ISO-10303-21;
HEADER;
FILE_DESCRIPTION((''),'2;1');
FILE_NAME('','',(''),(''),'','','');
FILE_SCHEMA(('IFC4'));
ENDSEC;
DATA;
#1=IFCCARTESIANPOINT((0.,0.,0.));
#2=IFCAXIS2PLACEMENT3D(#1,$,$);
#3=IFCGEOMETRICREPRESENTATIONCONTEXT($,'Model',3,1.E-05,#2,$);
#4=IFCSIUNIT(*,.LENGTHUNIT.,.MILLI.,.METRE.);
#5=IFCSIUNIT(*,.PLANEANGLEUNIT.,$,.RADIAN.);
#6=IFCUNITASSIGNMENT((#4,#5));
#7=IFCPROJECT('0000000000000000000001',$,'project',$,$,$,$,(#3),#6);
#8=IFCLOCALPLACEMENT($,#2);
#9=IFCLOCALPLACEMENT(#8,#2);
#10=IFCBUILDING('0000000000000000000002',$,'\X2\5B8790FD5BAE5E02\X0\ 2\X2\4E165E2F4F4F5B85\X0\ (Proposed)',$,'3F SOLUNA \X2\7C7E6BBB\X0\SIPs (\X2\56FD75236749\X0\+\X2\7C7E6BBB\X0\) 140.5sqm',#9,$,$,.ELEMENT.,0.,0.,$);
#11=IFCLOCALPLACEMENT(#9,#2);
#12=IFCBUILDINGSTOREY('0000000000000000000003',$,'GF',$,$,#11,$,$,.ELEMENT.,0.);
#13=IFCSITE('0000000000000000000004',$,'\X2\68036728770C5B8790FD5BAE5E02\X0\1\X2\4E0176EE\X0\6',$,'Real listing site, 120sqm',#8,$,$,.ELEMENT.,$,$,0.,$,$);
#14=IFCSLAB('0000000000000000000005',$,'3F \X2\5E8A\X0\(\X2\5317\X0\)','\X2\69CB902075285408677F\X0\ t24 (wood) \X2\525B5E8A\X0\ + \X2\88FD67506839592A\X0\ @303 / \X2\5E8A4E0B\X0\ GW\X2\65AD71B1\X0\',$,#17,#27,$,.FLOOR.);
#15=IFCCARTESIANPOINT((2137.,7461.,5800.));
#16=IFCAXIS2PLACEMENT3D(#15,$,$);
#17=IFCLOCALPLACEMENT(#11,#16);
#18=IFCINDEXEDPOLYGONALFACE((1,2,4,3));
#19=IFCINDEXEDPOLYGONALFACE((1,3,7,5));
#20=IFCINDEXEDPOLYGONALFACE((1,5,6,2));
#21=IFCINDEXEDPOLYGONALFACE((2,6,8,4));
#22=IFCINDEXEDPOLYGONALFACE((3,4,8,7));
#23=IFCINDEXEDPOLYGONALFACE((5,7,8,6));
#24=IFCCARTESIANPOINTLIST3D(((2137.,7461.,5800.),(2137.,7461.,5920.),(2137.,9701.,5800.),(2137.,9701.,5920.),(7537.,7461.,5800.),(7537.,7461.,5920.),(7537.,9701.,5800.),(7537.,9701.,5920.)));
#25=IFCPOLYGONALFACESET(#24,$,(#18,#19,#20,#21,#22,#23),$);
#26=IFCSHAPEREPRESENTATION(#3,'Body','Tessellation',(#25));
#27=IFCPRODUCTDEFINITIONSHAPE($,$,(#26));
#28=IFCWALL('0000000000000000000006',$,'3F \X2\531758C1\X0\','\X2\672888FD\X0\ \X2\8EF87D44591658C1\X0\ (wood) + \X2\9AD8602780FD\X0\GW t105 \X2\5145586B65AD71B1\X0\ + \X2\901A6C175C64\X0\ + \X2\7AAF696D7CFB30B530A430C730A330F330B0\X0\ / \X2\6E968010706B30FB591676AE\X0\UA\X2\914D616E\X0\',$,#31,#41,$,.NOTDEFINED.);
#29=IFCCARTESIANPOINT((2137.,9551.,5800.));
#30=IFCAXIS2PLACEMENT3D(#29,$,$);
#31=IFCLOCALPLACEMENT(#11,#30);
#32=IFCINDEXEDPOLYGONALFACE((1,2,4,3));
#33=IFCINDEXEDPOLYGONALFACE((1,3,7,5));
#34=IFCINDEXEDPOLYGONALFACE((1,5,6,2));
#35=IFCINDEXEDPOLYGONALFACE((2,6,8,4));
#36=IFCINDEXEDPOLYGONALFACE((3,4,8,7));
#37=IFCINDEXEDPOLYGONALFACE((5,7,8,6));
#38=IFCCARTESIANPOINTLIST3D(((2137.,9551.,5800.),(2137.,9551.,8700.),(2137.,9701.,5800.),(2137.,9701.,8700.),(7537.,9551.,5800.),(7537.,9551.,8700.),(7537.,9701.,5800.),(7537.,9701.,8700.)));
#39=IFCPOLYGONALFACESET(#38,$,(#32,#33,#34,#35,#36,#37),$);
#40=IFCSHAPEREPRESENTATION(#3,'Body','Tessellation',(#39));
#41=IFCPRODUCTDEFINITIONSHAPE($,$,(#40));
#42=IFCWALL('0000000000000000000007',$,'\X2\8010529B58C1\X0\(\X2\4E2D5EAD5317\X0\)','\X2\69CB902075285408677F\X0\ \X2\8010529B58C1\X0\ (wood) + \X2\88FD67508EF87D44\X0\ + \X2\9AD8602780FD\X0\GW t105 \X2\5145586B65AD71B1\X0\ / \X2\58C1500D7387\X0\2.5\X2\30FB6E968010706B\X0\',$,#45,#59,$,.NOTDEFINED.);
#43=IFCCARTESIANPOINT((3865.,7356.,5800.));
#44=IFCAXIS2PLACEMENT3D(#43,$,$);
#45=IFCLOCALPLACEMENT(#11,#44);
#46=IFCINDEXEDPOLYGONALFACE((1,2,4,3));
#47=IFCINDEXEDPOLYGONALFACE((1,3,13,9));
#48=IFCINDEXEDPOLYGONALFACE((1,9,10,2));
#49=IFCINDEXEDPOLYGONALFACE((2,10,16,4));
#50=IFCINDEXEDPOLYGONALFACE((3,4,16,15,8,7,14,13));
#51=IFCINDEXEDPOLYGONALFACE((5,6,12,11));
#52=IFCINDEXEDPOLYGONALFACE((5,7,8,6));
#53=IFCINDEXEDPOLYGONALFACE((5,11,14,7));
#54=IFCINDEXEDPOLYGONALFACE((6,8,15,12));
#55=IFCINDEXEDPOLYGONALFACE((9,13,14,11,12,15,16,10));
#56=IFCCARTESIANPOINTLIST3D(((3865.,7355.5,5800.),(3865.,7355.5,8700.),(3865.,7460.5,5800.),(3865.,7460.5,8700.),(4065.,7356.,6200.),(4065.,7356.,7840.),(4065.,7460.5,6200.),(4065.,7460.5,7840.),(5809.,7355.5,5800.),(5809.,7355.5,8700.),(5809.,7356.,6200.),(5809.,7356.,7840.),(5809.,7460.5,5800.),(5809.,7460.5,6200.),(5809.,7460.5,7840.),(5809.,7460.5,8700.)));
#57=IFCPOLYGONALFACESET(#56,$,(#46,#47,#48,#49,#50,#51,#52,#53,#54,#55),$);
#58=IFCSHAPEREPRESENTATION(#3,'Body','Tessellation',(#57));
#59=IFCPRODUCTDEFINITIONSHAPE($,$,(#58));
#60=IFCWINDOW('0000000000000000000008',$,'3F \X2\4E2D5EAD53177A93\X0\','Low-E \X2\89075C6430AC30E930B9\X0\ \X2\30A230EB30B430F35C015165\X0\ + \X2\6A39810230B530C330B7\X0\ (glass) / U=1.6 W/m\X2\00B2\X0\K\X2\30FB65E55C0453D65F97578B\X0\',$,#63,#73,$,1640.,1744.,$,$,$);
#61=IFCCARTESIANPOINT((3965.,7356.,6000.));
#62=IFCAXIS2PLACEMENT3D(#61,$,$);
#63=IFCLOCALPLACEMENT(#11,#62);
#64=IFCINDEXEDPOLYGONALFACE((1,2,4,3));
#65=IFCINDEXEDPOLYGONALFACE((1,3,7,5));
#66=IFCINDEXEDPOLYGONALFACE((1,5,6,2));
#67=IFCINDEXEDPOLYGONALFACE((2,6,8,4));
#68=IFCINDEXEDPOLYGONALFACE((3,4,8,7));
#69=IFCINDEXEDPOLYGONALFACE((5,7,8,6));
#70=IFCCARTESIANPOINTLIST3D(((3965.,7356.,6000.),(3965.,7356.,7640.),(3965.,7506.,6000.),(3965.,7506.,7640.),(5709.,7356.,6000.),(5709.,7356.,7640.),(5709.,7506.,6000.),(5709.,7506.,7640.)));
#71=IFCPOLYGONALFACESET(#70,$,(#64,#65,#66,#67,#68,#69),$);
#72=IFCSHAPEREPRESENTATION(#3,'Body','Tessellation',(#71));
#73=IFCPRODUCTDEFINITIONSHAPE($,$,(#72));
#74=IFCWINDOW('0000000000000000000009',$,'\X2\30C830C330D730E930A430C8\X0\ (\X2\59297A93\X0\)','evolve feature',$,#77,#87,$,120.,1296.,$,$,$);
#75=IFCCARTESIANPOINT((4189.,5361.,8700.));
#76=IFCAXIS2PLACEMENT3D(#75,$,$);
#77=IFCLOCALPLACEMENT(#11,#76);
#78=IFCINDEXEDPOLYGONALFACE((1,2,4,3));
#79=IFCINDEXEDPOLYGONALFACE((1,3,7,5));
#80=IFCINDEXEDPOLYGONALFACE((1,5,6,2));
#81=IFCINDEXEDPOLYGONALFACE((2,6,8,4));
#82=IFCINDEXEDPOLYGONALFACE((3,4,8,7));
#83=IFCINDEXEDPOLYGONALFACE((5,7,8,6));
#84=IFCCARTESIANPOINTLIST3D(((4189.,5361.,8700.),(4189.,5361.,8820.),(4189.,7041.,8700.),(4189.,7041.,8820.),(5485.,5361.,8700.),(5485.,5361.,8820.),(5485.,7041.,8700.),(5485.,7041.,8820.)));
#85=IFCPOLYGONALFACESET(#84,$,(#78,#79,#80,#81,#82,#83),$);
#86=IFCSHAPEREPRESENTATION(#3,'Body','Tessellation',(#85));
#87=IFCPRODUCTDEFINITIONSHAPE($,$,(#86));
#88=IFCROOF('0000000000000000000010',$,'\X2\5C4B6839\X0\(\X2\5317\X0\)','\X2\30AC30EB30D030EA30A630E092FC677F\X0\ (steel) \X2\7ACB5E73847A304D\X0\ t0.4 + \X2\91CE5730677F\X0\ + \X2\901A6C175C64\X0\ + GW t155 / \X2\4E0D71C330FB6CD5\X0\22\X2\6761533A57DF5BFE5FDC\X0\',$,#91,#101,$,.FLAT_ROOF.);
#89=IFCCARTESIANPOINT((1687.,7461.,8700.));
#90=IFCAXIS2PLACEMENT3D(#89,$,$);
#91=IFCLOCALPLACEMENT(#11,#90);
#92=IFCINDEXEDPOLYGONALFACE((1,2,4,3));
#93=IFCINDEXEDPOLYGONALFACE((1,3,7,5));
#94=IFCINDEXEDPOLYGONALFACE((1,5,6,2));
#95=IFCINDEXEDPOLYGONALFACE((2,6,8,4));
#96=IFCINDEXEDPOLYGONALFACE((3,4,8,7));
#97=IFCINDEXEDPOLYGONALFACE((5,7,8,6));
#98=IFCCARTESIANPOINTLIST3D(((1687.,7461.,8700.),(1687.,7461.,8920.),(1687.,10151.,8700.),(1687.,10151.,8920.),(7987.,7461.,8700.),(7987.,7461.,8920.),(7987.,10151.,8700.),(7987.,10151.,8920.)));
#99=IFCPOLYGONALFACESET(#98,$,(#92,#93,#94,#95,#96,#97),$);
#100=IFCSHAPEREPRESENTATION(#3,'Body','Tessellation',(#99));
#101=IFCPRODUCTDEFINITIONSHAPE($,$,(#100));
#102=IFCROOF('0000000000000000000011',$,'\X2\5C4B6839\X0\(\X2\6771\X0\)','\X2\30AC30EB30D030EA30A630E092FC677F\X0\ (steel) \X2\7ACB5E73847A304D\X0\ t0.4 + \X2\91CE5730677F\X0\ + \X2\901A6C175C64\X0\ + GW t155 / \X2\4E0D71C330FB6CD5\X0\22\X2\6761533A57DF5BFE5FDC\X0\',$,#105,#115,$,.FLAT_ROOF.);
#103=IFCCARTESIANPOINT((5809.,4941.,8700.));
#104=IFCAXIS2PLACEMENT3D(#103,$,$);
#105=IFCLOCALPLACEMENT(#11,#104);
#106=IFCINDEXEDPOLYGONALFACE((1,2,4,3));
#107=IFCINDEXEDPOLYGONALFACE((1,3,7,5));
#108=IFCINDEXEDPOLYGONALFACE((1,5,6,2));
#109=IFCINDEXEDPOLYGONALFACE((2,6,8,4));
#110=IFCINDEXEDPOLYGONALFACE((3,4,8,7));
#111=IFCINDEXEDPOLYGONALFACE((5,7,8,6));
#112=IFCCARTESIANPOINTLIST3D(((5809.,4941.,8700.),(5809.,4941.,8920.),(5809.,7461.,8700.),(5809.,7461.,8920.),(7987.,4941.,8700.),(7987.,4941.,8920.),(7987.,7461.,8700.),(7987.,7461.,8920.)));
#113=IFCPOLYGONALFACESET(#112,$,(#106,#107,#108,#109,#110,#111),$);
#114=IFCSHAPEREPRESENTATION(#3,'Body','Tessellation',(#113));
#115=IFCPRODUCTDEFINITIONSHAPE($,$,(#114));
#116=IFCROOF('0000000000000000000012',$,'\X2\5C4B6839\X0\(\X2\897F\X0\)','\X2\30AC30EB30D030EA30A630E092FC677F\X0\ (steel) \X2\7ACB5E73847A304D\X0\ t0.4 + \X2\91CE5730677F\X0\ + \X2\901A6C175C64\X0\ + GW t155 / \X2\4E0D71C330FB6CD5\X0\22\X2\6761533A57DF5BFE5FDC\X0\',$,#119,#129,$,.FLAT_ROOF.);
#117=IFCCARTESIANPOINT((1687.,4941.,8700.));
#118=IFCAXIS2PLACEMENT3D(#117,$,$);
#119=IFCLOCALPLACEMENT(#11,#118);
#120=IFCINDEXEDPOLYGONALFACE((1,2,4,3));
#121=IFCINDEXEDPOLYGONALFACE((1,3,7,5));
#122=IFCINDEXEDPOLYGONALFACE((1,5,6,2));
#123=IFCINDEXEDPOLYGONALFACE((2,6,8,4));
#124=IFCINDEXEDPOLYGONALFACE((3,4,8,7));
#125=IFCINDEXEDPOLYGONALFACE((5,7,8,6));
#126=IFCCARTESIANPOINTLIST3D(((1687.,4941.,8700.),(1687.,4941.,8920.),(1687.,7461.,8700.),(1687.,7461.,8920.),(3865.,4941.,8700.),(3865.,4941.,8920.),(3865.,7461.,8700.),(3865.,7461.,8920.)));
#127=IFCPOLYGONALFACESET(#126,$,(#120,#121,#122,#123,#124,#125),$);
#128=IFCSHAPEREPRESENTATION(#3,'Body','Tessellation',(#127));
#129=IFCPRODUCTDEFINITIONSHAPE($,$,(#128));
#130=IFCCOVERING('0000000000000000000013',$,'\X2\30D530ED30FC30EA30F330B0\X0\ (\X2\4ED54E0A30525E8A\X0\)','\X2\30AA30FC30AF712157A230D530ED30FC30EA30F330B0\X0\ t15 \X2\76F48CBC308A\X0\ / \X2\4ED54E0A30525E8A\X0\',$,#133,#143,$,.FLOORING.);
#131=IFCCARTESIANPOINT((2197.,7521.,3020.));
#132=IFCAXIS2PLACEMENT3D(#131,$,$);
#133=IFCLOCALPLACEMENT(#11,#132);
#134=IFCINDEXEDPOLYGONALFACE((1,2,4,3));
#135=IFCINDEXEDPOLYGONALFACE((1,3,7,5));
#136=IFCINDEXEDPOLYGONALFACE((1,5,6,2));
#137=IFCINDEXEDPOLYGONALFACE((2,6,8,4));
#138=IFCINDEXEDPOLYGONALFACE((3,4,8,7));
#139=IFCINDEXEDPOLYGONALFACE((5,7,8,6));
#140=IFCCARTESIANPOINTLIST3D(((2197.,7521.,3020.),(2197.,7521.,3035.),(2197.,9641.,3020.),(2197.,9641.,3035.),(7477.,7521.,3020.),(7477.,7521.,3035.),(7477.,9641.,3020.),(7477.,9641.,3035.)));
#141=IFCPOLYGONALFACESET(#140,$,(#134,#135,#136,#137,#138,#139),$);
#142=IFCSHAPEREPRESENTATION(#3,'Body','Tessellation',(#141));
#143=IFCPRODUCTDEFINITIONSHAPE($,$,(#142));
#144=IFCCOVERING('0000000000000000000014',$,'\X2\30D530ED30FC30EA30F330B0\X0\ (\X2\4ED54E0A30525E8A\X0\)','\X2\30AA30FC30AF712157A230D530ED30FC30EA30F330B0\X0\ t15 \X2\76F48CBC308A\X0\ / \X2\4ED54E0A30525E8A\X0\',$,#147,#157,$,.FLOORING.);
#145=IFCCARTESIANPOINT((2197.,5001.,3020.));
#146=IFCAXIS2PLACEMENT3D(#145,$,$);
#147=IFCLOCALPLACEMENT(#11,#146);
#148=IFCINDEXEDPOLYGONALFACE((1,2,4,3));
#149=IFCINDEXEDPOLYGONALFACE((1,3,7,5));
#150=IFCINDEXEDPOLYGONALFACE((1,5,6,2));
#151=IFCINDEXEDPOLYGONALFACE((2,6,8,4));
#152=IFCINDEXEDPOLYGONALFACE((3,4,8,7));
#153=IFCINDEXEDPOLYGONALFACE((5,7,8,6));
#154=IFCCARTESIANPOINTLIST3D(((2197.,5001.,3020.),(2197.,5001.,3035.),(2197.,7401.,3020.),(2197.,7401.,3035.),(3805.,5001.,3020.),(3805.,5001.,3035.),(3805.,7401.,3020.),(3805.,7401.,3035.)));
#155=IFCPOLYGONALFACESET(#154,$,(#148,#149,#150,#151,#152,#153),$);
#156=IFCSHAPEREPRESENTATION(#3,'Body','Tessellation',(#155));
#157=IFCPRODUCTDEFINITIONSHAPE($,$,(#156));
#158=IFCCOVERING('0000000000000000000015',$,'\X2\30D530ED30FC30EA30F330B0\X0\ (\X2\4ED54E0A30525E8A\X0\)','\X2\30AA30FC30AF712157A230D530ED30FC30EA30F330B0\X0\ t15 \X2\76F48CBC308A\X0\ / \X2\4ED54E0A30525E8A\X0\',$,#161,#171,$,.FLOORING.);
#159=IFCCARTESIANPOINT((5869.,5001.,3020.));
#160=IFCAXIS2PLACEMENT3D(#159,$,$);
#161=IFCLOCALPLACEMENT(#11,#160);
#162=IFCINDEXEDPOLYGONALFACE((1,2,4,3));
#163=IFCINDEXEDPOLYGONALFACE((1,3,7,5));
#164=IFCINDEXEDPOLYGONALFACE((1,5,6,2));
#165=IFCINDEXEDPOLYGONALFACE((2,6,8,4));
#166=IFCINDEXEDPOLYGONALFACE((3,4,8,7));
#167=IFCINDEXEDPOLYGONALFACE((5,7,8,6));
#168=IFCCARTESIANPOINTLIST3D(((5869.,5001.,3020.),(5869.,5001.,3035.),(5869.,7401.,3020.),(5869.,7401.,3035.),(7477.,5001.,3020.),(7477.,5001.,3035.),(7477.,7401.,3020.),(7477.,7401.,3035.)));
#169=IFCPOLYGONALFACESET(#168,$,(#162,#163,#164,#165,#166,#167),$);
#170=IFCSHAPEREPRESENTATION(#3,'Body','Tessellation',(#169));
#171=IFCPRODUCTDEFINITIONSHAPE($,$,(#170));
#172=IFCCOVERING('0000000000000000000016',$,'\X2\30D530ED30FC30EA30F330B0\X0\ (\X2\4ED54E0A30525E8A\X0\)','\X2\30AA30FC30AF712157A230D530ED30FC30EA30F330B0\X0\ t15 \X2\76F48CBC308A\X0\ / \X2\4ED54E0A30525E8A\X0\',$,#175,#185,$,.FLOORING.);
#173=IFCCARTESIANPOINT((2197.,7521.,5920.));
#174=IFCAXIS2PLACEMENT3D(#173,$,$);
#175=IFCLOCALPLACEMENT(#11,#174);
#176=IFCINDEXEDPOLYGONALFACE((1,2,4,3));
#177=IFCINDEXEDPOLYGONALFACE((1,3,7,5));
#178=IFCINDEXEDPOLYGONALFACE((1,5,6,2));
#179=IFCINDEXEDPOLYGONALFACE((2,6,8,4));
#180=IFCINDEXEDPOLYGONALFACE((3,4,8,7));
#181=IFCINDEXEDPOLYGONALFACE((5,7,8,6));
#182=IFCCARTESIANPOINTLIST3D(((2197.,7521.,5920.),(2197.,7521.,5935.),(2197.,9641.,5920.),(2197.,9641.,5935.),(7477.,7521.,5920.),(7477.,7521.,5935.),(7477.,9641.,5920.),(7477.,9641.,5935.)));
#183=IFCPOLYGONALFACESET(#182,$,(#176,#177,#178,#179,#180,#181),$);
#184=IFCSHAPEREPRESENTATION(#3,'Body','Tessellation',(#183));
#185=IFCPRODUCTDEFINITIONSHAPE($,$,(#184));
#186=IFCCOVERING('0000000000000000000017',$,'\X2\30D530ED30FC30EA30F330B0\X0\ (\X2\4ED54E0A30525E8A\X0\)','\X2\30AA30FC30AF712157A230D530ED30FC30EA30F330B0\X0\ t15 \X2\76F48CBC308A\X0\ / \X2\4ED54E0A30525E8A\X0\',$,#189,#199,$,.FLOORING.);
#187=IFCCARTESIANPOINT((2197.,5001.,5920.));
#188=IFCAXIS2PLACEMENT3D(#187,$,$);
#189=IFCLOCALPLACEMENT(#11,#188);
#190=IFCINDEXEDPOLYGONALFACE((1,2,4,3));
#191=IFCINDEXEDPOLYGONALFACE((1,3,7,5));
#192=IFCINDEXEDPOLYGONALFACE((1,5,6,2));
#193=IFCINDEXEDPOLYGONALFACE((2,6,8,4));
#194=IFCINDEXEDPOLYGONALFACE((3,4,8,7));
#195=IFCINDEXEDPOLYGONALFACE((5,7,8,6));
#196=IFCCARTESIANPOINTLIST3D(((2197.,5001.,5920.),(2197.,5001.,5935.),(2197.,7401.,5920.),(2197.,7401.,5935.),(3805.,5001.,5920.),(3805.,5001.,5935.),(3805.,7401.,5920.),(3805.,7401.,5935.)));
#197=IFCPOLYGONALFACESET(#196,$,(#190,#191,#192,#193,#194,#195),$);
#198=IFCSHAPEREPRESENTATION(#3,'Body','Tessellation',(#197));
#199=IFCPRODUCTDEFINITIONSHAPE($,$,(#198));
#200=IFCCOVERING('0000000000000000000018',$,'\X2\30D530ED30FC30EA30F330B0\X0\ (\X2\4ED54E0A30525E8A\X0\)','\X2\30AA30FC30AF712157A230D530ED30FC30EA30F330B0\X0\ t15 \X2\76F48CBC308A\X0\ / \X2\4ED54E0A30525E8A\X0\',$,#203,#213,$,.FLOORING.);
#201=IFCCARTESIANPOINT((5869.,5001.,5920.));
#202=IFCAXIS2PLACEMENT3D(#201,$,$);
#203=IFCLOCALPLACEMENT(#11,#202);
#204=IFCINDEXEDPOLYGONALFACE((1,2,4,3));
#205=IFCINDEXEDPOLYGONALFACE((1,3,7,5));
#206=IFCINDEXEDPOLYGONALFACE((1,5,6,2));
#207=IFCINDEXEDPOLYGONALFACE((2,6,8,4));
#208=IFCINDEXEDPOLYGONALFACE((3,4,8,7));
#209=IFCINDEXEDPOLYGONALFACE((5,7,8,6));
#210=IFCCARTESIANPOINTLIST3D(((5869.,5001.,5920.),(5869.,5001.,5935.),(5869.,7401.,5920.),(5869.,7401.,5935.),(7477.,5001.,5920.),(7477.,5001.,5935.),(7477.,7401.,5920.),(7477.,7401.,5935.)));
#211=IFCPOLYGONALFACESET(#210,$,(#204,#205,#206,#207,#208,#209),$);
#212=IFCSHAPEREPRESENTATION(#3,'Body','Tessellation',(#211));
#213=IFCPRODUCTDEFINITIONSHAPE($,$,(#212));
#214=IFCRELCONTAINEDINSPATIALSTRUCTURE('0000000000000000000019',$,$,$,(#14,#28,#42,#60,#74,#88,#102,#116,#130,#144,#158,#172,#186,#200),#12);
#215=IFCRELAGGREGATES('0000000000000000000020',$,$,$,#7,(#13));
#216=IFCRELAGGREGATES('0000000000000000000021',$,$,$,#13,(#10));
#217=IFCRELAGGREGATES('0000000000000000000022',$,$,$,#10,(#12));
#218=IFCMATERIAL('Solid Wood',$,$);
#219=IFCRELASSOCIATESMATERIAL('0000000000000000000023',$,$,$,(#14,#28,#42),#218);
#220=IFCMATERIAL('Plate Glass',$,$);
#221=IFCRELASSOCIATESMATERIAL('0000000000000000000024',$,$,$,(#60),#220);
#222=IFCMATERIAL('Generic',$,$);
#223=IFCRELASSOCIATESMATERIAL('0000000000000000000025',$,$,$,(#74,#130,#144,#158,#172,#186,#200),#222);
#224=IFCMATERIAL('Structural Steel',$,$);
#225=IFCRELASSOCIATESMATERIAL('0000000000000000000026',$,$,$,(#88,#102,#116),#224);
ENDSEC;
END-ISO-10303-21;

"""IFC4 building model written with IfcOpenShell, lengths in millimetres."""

from ifc_helpers import new_model, si_unit, frame, frame_2d, origin, place, context, project, spatial, rectangle, extrude, material, element, fill, save


model = new_model("IFC4")

# Units and contexts
model_context = context("Model", 3, precision=1e-05, world=origin())
ifc_project = project(units=[si_unit("LENGTHUNIT", "METRE", prefix="MILLI"), si_unit("PLANEANGLEUNIT", "RADIAN")], contexts=[model_context])

# Site, building, storey
site_placement = place(None, origin())
site = spatial("IfcSite", under=ifc_project, at=site_placement, Name="栃木県宇都宮市1丁目6", ObjectType="Real listing site, 120sqm", CompositionType="ELEMENT", RefElevation=0.0)
building_placement = place(site_placement, origin())
building = spatial("IfcBuilding", under=site, at=building_placement, Name="宇都宮市 2世帯住宅 (Proposed)", ObjectType="3F SOLUNA 籾殻SIPs (国産杉+籾殻) 140.5sqm", CompositionType="ELEMENT", ElevationOfRefHeight=0.0, ElevationOfTerrain=0.0)
storey_placement = place(building_placement, origin())
storey = spatial("IfcBuildingStorey", under=building, at=storey_placement, Name="GF", CompositionType="ELEMENT", Elevation=0.0)

# Slab
ifc_material_1 = material(Name="Solid Wood")
slab_placement = place(storey_placement, frame((2137.0, 7461.0, 5800.0)))
element("IfcSlab", 1, at=slab_placement, inside=storey, material=ifc_material_1, Name="3F 床(北)", Description="構造用合板 t24 (wood) 剛床 + 製材根太 @303 / 床下 GW断熱", PredefinedType="FLOOR", context=model_context, shape_type="SweptSolid", body=[
    extrude(rectangle(XDim=5400.0, YDim=2240.0, at=frame_2d((2700.0, 1120.0))), frame((2137.0, 7461.0, 5800.0)), (0.0, 0.0, 1.0), 120.0),
])

# Wall
wall_1_placement = place(storey_placement, frame((2137.0, 9551.0, 5800.0)))
element("IfcWall", 2, at=wall_1_placement, inside=storey, material=ifc_material_1, Name="3F 北壁", Description="木製 軸組外壁 (wood) + 高性能GW t105 充填断熱 + 通気層 + 窯業系サイディング / 準耐火・外皮UA配慮", PredefinedType="NOTDEFINED", context=model_context, shape_type="SweptSolid", body=[
    extrude(rectangle(XDim=5400.0, YDim=150.0, at=frame_2d((2700.0, 75.0))), frame((2137.0, 9551.0, 5800.0)), (0.0, 0.0, 1.0), 2900.0),
])

# Wall, opening, window
wall_2_placement = place(storey_placement, frame((3865.0, 7356.0, 5800.0)))
wall_2 = element("IfcWall", 3, at=wall_2_placement, inside=storey, material=ifc_material_1, Name="耐力壁(中庭北)", Description="構造用合板 耐力壁 (wood) + 製材軸組 + 高性能GW t105 充填断熱 / 壁倍率2.5・準耐火", PredefinedType="NOTDEFINED", context=model_context, shape_type="SweptSolid", body=[
    extrude(rectangle(XDim=1944.0, YDim=105.0, at=frame_2d((972.0, 52.0))), frame((3865.0, 7356.0, 5800.0)), (0.0, 0.0, 1.0), 2900.0),
])
opening_placement = place(storey_placement, frame((3965.0, 7356.0, 6000.0)))
opening = element("IfcOpeningElement", 4, at=opening_placement, cuts=wall_2, PredefinedType="NOTDEFINED", context=model_context, shape_type="SweptSolid", body=[
    extrude(rectangle(XDim=1744.0, YDim=150.0, at=frame_2d((872.0, 75.0))), frame((3965.0, 7356.0, 6000.0)), (0.0, 0.0, 1.0), 1640.0),
])
ifc_material_2 = material(Name="Plate Glass")
window_1_placement = place(storey_placement, frame((3965.0, 7356.0, 6000.0)))
window_1 = element("IfcWindow", 5, at=window_1_placement, inside=storey, material=ifc_material_2, Name="3F 中庭北窓", Description="Low-E 複層ガラス アルゴン封入 + 樹脂サッシ (glass) / U=1.6 W/m²K・日射取得型", OverallHeight=1640.0, OverallWidth=1744.0, context=model_context, shape_type="SweptSolid", body=[
    extrude(rectangle(XDim=1744.0, YDim=150.0, at=frame_2d((872.0, 75.0))), frame((3965.0, 7356.0, 6000.0)), (0.0, 0.0, 1.0), 1640.0),
])
fill(opening, window_1)

# Window
ifc_material_3 = material(Name="Generic")
window_2_placement = place(storey_placement, frame((4189.0, 5361.0, 8700.0)))
element("IfcWindow", 6, at=window_2_placement, inside=storey, material=ifc_material_3, Name="トップライト (天窓)", Description="evolve feature", OverallHeight=120.0, OverallWidth=1296.0, context=model_context, shape_type="SweptSolid", body=[
    extrude(rectangle(XDim=1296.0, YDim=1680.0, at=frame_2d((648.0, 840.0))), frame((4189.0, 5361.0, 8700.0)), (0.0, 0.0, 1.0), 120.0),
])

# Roofs
ifc_material_4 = material(Name="Structural Steel")
roof_1_placement = place(storey_placement, frame((1687.0, 7461.0, 8700.0)))
element("IfcRoof", 7, at=roof_1_placement, inside=storey, material=ifc_material_4, Name="屋根(北)", Description="ガルバリウム鋼板 (steel) 立平葺き t0.4 + 野地板 + 通気層 + GW t155 / 不燃・法22条区域対応", PredefinedType="FLAT_ROOF", context=model_context, shape_type="SweptSolid", body=[
    extrude(rectangle(XDim=6300.0, YDim=2690.0, at=frame_2d((3150.0, 1345.0))), frame((1687.0, 7461.0, 8700.0)), (0.0, 0.0, 1.0), 220.0),
])
roof_2_placement = place(storey_placement, frame((5809.0, 4941.0, 8700.0)))
element("IfcRoof", 8, at=roof_2_placement, inside=storey, material=ifc_material_4, Name="屋根(東)", Description="ガルバリウム鋼板 (steel) 立平葺き t0.4 + 野地板 + 通気層 + GW t155 / 不燃・法22条区域対応", PredefinedType="FLAT_ROOF", context=model_context, shape_type="SweptSolid", body=[
    extrude(rectangle(XDim=2178.0, YDim=2520.0, at=frame_2d((1089.0, 1260.0))), frame((5809.0, 4941.0, 8700.0)), (0.0, 0.0, 1.0), 220.0),
])
roof_3_placement = place(storey_placement, frame((1687.0, 4941.0, 8700.0)))
element("IfcRoof", 9, at=roof_3_placement, inside=storey, material=ifc_material_4, Name="屋根(西)", Description="ガルバリウム鋼板 (steel) 立平葺き t0.4 + 野地板 + 通気層 + GW t155 / 不燃・法22条区域対応", PredefinedType="FLAT_ROOF", context=model_context, shape_type="SweptSolid", body=[
    extrude(rectangle(XDim=2178.0, YDim=2520.0, at=frame_2d((1089.0, 1260.0))), frame((1687.0, 4941.0, 8700.0)), (0.0, 0.0, 1.0), 220.0),
])

# Coverings
covering_1_placement = place(storey_placement, frame((2197.0, 7521.0, 3020.0)))
element("IfcCovering", 10, at=covering_1_placement, inside=storey, material=ifc_material_3, Name="フローリング (仕上げ床)", Description="オーク無垢フローリング t15 直貼り / 仕上げ床", PredefinedType="FLOORING", context=model_context, shape_type="SweptSolid", body=[
    extrude(rectangle(XDim=5280.0, YDim=2120.0, at=frame_2d((2640.0, 1060.0))), frame((2197.0, 7521.0, 3020.0)), (0.0, 0.0, 1.0), 15.0),
])
covering_2_placement = place(storey_placement, frame((2197.0, 5001.0, 3020.0)))
element("IfcCovering", 11, at=covering_2_placement, inside=storey, material=ifc_material_3, Name="フローリング (仕上げ床)", Description="オーク無垢フローリング t15 直貼り / 仕上げ床", PredefinedType="FLOORING", context=model_context, shape_type="SweptSolid", body=[
    extrude(rectangle(XDim=1608.0, YDim=2400.0, at=frame_2d((804.0, 1200.0))), frame((2197.0, 5001.0, 3020.0)), (0.0, 0.0, 1.0), 15.0),
])
covering_3_placement = place(storey_placement, frame((5869.0, 5001.0, 3020.0)))
element("IfcCovering", 12, at=covering_3_placement, inside=storey, material=ifc_material_3, Name="フローリング (仕上げ床)", Description="オーク無垢フローリング t15 直貼り / 仕上げ床", PredefinedType="FLOORING", context=model_context, shape_type="SweptSolid", body=[
    extrude(rectangle(XDim=1608.0, YDim=2400.0, at=frame_2d((804.0, 1200.0))), frame((5869.0, 5001.0, 3020.0)), (0.0, 0.0, 1.0), 15.0),
])
covering_4_placement = place(storey_placement, frame((2197.0, 7521.0, 5920.0)))
element("IfcCovering", 13, at=covering_4_placement, inside=storey, material=ifc_material_3, Name="フローリング (仕上げ床)", Description="オーク無垢フローリング t15 直貼り / 仕上げ床", PredefinedType="FLOORING", context=model_context, shape_type="SweptSolid", body=[
    extrude(rectangle(XDim=5280.0, YDim=2120.0, at=frame_2d((2640.0, 1060.0))), frame((2197.0, 7521.0, 5920.0)), (0.0, 0.0, 1.0), 15.0),
])
covering_5_placement = place(storey_placement, frame((2197.0, 5001.0, 5920.0)))
element("IfcCovering", 14, at=covering_5_placement, inside=storey, material=ifc_material_3, Name="フローリング (仕上げ床)", Description="オーク無垢フローリング t15 直貼り / 仕上げ床", PredefinedType="FLOORING", context=model_context, shape_type="SweptSolid", body=[
    extrude(rectangle(XDim=1608.0, YDim=2400.0, at=frame_2d((804.0, 1200.0))), frame((2197.0, 5001.0, 5920.0)), (0.0, 0.0, 1.0), 15.0),
])
covering_6_placement = place(storey_placement, frame((5869.0, 5001.0, 5920.0)))
element("IfcCovering", 15, at=covering_6_placement, inside=storey, material=ifc_material_3, Name="フローリング (仕上げ床)", Description="オーク無垢フローリング t15 直貼り / 仕上げ床", PredefinedType="FLOORING", context=model_context, shape_type="SweptSolid", body=[
    extrude(rectangle(XDim=1608.0, YDim=2400.0, at=frame_2d((804.0, 1200.0))), frame((5869.0, 5001.0, 5920.0)), (0.0, 0.0, 1.0), 15.0),
])

save(model, "model.ifc")
